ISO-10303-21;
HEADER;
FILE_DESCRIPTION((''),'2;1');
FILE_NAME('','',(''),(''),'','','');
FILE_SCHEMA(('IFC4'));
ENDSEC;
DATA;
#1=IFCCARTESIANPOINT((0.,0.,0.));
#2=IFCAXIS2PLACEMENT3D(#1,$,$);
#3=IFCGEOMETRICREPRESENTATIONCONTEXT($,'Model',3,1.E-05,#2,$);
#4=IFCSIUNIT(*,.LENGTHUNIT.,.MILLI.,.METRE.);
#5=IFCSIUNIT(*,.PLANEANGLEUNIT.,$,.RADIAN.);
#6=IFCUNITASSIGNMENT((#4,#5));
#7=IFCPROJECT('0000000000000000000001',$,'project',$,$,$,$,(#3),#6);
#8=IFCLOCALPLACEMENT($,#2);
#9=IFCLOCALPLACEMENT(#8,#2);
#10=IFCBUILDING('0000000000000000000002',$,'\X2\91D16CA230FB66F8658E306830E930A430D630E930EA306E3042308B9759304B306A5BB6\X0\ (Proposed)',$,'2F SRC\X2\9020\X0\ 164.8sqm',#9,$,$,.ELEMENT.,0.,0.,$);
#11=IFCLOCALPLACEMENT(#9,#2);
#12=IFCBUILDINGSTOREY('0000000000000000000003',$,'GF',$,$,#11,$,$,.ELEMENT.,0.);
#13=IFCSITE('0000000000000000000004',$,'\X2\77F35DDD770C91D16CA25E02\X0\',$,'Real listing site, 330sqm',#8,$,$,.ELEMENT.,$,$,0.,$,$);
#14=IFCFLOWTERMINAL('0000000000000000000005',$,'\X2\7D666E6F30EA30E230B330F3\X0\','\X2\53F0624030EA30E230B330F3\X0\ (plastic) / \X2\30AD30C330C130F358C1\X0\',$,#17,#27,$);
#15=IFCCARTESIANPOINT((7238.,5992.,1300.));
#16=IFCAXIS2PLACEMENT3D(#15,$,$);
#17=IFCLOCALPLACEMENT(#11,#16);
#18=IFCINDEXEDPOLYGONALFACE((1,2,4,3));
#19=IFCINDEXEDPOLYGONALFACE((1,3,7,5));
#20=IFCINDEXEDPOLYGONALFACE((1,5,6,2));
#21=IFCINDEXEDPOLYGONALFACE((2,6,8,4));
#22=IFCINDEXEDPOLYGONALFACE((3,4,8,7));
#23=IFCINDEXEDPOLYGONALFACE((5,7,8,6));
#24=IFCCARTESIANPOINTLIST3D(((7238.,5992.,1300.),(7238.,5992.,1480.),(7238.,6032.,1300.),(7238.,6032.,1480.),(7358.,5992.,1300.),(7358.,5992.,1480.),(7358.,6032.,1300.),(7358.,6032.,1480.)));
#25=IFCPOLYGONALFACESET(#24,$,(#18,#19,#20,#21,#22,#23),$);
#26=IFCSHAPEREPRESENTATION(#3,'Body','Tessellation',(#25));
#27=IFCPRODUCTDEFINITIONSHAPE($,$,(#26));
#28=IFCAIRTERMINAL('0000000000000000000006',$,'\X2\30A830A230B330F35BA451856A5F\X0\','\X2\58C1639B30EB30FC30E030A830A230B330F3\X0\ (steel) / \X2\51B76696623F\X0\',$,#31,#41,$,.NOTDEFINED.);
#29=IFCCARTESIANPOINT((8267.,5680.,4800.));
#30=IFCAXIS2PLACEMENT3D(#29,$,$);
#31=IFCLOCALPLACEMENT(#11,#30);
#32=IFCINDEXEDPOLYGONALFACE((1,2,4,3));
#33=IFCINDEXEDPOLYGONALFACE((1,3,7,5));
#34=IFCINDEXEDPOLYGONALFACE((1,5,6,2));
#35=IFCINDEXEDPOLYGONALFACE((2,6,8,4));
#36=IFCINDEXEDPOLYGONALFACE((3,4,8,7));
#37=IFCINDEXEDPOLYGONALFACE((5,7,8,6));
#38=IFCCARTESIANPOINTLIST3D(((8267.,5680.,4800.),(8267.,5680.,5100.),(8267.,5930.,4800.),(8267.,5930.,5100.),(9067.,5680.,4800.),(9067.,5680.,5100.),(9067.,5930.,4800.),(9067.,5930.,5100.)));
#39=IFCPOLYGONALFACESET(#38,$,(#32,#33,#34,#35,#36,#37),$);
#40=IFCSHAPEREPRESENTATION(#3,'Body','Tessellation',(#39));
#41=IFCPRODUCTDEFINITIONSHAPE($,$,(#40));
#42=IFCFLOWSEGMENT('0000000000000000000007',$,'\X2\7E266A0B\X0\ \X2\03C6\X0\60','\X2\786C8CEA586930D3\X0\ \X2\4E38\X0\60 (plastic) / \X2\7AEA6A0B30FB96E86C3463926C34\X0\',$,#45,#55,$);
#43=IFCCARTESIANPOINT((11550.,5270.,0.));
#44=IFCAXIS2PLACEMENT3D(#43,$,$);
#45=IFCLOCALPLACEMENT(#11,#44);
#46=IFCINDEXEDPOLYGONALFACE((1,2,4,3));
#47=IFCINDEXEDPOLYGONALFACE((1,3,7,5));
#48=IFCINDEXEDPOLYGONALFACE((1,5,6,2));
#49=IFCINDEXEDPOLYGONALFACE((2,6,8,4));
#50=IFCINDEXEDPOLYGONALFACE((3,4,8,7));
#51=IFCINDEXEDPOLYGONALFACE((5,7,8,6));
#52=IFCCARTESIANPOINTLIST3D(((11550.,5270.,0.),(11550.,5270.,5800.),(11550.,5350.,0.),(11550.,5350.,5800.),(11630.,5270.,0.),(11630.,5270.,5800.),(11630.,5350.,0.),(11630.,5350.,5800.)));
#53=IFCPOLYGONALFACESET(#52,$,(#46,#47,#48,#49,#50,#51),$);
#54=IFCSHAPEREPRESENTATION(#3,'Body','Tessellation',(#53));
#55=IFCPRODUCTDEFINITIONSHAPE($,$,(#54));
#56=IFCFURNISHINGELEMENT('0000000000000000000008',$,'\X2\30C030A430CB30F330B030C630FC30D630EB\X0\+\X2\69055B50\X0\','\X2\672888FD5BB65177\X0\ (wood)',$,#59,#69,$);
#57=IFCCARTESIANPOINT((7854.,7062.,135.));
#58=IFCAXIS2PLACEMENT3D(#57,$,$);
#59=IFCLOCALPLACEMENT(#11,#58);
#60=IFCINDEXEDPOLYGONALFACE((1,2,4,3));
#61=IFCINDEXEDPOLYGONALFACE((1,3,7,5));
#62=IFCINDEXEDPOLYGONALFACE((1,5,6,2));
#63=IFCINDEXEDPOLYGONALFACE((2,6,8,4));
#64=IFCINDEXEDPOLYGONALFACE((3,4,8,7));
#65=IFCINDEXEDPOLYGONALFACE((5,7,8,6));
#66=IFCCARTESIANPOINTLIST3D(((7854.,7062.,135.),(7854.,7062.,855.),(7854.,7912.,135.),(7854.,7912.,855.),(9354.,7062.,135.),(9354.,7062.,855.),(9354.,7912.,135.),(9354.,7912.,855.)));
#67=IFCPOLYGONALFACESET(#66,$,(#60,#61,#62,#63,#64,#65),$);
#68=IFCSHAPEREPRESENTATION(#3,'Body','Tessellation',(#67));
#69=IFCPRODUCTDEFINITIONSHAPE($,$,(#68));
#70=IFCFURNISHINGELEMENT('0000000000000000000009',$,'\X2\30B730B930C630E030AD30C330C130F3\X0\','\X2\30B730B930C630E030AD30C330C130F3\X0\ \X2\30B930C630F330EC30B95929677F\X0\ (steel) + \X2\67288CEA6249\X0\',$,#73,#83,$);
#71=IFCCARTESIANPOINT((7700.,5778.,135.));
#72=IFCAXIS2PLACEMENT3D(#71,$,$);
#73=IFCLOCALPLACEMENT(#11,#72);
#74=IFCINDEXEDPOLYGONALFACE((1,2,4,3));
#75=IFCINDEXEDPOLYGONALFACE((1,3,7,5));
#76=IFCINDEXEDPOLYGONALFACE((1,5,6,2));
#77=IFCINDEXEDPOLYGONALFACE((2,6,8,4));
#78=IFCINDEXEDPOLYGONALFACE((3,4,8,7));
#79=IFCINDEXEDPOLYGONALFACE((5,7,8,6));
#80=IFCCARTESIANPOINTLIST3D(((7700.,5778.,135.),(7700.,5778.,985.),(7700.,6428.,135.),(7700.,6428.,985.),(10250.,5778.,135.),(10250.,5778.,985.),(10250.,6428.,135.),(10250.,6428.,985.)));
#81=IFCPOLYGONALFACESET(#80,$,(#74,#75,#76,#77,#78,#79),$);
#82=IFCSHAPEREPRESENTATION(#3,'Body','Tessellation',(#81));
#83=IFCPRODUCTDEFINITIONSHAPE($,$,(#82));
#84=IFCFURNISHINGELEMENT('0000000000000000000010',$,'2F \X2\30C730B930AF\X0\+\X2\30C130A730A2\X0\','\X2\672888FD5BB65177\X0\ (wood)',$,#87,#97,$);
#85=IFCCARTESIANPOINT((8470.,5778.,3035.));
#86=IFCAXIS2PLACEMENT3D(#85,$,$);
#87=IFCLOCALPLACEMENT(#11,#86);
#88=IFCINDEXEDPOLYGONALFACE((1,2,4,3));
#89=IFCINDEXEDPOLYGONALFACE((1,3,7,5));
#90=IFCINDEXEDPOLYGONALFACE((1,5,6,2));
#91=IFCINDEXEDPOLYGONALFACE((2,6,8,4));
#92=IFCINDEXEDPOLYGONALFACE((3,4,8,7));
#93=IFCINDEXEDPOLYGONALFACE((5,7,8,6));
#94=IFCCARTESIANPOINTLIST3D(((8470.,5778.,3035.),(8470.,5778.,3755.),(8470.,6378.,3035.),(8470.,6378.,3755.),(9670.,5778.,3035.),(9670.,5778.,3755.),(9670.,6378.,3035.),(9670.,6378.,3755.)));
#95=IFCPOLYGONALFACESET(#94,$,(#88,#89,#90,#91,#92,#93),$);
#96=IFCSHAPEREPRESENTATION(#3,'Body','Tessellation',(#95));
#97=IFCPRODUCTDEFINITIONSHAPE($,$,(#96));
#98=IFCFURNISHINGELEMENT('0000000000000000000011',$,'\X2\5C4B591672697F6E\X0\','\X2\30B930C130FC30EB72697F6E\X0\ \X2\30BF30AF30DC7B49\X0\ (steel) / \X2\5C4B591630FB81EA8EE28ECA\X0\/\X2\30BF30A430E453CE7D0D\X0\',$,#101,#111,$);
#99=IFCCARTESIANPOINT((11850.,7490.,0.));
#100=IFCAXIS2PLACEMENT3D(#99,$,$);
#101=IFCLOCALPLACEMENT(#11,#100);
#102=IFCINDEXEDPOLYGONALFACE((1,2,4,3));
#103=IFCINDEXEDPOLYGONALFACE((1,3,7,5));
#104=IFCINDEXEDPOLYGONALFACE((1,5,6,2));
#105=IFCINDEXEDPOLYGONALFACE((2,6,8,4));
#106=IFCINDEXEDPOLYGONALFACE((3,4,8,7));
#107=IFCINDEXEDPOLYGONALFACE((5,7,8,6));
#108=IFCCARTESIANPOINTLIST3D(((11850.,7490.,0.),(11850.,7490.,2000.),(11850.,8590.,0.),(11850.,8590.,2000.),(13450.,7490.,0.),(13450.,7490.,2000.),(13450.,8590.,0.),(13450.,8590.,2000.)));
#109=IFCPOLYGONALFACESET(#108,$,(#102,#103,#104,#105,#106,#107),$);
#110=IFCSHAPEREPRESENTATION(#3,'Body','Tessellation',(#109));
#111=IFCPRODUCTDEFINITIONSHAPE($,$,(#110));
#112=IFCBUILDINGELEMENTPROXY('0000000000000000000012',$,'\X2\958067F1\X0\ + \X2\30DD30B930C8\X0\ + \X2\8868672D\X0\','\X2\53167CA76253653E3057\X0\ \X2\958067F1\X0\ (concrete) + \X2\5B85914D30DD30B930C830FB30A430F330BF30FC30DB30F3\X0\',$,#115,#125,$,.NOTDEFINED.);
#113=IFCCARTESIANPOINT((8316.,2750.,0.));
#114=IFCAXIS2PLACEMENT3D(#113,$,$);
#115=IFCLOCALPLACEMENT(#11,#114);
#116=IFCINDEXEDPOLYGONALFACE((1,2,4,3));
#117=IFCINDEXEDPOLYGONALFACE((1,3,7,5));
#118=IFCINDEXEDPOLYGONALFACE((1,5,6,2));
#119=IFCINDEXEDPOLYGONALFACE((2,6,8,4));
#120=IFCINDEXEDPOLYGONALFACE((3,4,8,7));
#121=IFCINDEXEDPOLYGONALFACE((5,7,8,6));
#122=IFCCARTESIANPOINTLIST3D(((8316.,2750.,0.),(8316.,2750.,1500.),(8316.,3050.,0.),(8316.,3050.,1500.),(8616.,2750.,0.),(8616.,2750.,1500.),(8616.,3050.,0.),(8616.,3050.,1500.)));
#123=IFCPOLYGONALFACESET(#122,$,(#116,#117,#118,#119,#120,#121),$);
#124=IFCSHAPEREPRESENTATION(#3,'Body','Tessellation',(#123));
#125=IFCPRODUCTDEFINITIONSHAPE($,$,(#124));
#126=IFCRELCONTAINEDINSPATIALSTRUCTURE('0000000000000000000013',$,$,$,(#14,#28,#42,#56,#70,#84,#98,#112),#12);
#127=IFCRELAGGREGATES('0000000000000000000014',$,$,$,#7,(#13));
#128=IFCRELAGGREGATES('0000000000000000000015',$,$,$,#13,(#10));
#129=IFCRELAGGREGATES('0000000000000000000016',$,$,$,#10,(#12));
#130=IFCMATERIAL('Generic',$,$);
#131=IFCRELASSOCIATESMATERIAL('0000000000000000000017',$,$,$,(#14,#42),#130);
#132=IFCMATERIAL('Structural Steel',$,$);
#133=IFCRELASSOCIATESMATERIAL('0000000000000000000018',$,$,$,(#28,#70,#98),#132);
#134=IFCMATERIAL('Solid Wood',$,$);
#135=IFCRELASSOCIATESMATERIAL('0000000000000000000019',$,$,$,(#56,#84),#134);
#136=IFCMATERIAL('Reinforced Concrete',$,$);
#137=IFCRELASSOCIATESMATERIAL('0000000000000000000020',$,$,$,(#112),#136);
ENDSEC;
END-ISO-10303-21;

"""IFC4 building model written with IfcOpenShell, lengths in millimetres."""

from ifc_helpers import new_model, si_unit, frame, frame_2d, origin, place, context, project, spatial, rectangle, extrude, material, element, save


model = new_model("IFC4")

# Units and contexts
model_context = context("Model", 3, precision=1e-05, world=origin())
ifc_project = project(units=[si_unit("LENGTHUNIT", "METRE", prefix="MILLI"), si_unit("PLANEANGLEUNIT", "RADIAN")], contexts=[model_context])

# Site, building, storey
site_placement = place(None, origin())
site = spatial("IfcSite", under=ifc_project, at=site_placement, Name="石川県金沢市", ObjectType="Real listing site, 330sqm", CompositionType="ELEMENT", RefElevation=0.0)
building_placement = place(site_placement, origin())
building = spatial("IfcBuilding", under=site, at=building_placement, Name="金沢・書斎とライブラリのある静かな家 (Proposed)", ObjectType="2F SRC造 164.8sqm", CompositionType="ELEMENT", ElevationOfRefHeight=0.0, ElevationOfTerrain=0.0)
storey_placement = place(building_placement, origin())
storey = spatial("IfcBuildingStorey", under=building, at=storey_placement, Name="GF", CompositionType="ELEMENT", Elevation=0.0)

# Shared definitions
ifc_material_1 = material(Name="Solid Wood")

# Shared definitions
ifc_material_2 = material(Name="Reinforced Concrete")

# Shared definitions
ifc_material_3 = material(Name="Structural Steel")

# Flow terminal
ifc_material_4 = material(Name="Generic")
flow_terminal_1_placement = place(storey_placement, frame((7238.0, 5992.0, 1300.0)))
element("IfcFlowTerminal", 1, at=flow_terminal_1_placement, inside=storey, material=ifc_material_4, Name="給湯リモコン", Description="台所リモコン (plastic) / キッチン壁", context=model_context, shape_type="SweptSolid", body=[
    extrude(rectangle(XDim=120.0, YDim=40.0, at=frame_2d((60.0, 20.0))), frame((7238.0, 5992.0, 1300.0)), (0.0, 0.0, 1.0), 180.0),
])

# Air terminal
air_terminal_placement = place(storey_placement, frame((8267.0, 5680.0, 4800.0)))
element("IfcAirTerminal", 2, at=air_terminal_placement, inside=storey, material=ifc_material_3, Name="エアコン室内機", Description="壁掛ルームエアコン (steel) / 冷暖房", PredefinedType="NOTDEFINED", context=model_context, shape_type="SweptSolid", body=[
    extrude(rectangle(XDim=800.0, YDim=250.0, at=frame_2d((400.0, 125.0))), frame((8267.0, 5680.0, 4800.0)), (0.0, 0.0, 1.0), 300.0),
])

# Flow segment
flow_segment_placement = place(storey_placement, frame((11550.0, 5270.0, 0.0)))
element("IfcFlowSegment", 3, at=flow_segment_placement, inside=storey, material=ifc_material_4, Name="縦樋 φ60", Description="硬質塩ビ 丸60 (plastic) / 竪樋・雨水排水", context=model_context, shape_type="SweptSolid", body=[
    extrude(rectangle(XDim=80.0, YDim=80.0, at=frame_2d((40.0, 40.0))), frame((11550.0, 5270.0, 0.0)), (0.0, 0.0, 1.0), 5800.0),
])

# Furnishing elements
furnishing_1_placement = place(storey_placement, frame((7854.0, 7062.0, 135.0)))
element("IfcFurnishingElement", 4, at=furnishing_1_placement, inside=storey, material=ifc_material_1, Name="ダイニングテーブル+椅子", Description="木製家具 (wood)", context=model_context, shape_type="SweptSolid", body=[
    extrude(rectangle(XDim=1500.0, YDim=850.0, at=frame_2d((750.0, 425.0))), frame((7854.0, 7062.0, 135.0)), (0.0, 0.0, 1.0), 720.0),
])
furnishing_2_placement = place(storey_placement, frame((7700.0, 5778.0, 135.0)))
element("IfcFurnishingElement", 5, at=furnishing_2_placement, inside=storey, material=ifc_material_3, Name="システムキッチン", Description="システムキッチン ステンレス天板 (steel) + 木質扉", context=model_context, shape_type="SweptSolid", body=[
    extrude(rectangle(XDim=2550.0, YDim=650.0, at=frame_2d((1275.0, 325.0))), frame((7700.0, 5778.0, 135.0)), (0.0, 0.0, 1.0), 850.0),
])
furnishing_3_placement = place(storey_placement, frame((8470.0, 5778.0, 3035.0)))
element("IfcFurnishingElement", 6, at=furnishing_3_placement, inside=storey, material=ifc_material_1, Name="2F デスク+チェア", Description="木製家具 (wood)", context=model_context, shape_type="SweptSolid", body=[
    extrude(rectangle(XDim=1200.0, YDim=600.0, at=frame_2d((600.0, 300.0))), frame((8470.0, 5778.0, 3035.0)), (0.0, 0.0, 1.0), 720.0),
])
furnishing_4_placement = place(storey_placement, frame((11850.0, 7490.0, 0.0)))
element("IfcFurnishingElement", 7, at=furnishing_4_placement, inside=storey, material=ifc_material_3, Name="屋外物置", Description="スチール物置 タクボ等 (steel) / 屋外・自転車/タイヤ収納", context=model_context, shape_type="SweptSolid", body=[
    extrude(rectangle(XDim=1600.0, YDim=1100.0, at=frame_2d((800.0, 550.0))), frame((11850.0, 7490.0, 0.0)), (0.0, 0.0, 1.0), 2000.0),
])

# Building element proxy
proxy_placement = place(storey_placement, frame((8316.0, 2750.0, 0.0)))
element("IfcBuildingElementProxy", 8, at=proxy_placement, inside=storey, material=ifc_material_2, Name="門柱 + ポスト + 表札", Description="化粧打放し 門柱 (concrete) + 宅配ポスト・インターホン", PredefinedType="NOTDEFINED", context=model_context, shape_type="SweptSolid", body=[
    extrude(rectangle(XDim=300.0, YDim=300.0, at=frame_2d((150.0, 150.0))), frame((8316.0, 2750.0, 0.0)), (0.0, 0.0, 1.0), 1500.0),
])

save(model, "model.ifc")
